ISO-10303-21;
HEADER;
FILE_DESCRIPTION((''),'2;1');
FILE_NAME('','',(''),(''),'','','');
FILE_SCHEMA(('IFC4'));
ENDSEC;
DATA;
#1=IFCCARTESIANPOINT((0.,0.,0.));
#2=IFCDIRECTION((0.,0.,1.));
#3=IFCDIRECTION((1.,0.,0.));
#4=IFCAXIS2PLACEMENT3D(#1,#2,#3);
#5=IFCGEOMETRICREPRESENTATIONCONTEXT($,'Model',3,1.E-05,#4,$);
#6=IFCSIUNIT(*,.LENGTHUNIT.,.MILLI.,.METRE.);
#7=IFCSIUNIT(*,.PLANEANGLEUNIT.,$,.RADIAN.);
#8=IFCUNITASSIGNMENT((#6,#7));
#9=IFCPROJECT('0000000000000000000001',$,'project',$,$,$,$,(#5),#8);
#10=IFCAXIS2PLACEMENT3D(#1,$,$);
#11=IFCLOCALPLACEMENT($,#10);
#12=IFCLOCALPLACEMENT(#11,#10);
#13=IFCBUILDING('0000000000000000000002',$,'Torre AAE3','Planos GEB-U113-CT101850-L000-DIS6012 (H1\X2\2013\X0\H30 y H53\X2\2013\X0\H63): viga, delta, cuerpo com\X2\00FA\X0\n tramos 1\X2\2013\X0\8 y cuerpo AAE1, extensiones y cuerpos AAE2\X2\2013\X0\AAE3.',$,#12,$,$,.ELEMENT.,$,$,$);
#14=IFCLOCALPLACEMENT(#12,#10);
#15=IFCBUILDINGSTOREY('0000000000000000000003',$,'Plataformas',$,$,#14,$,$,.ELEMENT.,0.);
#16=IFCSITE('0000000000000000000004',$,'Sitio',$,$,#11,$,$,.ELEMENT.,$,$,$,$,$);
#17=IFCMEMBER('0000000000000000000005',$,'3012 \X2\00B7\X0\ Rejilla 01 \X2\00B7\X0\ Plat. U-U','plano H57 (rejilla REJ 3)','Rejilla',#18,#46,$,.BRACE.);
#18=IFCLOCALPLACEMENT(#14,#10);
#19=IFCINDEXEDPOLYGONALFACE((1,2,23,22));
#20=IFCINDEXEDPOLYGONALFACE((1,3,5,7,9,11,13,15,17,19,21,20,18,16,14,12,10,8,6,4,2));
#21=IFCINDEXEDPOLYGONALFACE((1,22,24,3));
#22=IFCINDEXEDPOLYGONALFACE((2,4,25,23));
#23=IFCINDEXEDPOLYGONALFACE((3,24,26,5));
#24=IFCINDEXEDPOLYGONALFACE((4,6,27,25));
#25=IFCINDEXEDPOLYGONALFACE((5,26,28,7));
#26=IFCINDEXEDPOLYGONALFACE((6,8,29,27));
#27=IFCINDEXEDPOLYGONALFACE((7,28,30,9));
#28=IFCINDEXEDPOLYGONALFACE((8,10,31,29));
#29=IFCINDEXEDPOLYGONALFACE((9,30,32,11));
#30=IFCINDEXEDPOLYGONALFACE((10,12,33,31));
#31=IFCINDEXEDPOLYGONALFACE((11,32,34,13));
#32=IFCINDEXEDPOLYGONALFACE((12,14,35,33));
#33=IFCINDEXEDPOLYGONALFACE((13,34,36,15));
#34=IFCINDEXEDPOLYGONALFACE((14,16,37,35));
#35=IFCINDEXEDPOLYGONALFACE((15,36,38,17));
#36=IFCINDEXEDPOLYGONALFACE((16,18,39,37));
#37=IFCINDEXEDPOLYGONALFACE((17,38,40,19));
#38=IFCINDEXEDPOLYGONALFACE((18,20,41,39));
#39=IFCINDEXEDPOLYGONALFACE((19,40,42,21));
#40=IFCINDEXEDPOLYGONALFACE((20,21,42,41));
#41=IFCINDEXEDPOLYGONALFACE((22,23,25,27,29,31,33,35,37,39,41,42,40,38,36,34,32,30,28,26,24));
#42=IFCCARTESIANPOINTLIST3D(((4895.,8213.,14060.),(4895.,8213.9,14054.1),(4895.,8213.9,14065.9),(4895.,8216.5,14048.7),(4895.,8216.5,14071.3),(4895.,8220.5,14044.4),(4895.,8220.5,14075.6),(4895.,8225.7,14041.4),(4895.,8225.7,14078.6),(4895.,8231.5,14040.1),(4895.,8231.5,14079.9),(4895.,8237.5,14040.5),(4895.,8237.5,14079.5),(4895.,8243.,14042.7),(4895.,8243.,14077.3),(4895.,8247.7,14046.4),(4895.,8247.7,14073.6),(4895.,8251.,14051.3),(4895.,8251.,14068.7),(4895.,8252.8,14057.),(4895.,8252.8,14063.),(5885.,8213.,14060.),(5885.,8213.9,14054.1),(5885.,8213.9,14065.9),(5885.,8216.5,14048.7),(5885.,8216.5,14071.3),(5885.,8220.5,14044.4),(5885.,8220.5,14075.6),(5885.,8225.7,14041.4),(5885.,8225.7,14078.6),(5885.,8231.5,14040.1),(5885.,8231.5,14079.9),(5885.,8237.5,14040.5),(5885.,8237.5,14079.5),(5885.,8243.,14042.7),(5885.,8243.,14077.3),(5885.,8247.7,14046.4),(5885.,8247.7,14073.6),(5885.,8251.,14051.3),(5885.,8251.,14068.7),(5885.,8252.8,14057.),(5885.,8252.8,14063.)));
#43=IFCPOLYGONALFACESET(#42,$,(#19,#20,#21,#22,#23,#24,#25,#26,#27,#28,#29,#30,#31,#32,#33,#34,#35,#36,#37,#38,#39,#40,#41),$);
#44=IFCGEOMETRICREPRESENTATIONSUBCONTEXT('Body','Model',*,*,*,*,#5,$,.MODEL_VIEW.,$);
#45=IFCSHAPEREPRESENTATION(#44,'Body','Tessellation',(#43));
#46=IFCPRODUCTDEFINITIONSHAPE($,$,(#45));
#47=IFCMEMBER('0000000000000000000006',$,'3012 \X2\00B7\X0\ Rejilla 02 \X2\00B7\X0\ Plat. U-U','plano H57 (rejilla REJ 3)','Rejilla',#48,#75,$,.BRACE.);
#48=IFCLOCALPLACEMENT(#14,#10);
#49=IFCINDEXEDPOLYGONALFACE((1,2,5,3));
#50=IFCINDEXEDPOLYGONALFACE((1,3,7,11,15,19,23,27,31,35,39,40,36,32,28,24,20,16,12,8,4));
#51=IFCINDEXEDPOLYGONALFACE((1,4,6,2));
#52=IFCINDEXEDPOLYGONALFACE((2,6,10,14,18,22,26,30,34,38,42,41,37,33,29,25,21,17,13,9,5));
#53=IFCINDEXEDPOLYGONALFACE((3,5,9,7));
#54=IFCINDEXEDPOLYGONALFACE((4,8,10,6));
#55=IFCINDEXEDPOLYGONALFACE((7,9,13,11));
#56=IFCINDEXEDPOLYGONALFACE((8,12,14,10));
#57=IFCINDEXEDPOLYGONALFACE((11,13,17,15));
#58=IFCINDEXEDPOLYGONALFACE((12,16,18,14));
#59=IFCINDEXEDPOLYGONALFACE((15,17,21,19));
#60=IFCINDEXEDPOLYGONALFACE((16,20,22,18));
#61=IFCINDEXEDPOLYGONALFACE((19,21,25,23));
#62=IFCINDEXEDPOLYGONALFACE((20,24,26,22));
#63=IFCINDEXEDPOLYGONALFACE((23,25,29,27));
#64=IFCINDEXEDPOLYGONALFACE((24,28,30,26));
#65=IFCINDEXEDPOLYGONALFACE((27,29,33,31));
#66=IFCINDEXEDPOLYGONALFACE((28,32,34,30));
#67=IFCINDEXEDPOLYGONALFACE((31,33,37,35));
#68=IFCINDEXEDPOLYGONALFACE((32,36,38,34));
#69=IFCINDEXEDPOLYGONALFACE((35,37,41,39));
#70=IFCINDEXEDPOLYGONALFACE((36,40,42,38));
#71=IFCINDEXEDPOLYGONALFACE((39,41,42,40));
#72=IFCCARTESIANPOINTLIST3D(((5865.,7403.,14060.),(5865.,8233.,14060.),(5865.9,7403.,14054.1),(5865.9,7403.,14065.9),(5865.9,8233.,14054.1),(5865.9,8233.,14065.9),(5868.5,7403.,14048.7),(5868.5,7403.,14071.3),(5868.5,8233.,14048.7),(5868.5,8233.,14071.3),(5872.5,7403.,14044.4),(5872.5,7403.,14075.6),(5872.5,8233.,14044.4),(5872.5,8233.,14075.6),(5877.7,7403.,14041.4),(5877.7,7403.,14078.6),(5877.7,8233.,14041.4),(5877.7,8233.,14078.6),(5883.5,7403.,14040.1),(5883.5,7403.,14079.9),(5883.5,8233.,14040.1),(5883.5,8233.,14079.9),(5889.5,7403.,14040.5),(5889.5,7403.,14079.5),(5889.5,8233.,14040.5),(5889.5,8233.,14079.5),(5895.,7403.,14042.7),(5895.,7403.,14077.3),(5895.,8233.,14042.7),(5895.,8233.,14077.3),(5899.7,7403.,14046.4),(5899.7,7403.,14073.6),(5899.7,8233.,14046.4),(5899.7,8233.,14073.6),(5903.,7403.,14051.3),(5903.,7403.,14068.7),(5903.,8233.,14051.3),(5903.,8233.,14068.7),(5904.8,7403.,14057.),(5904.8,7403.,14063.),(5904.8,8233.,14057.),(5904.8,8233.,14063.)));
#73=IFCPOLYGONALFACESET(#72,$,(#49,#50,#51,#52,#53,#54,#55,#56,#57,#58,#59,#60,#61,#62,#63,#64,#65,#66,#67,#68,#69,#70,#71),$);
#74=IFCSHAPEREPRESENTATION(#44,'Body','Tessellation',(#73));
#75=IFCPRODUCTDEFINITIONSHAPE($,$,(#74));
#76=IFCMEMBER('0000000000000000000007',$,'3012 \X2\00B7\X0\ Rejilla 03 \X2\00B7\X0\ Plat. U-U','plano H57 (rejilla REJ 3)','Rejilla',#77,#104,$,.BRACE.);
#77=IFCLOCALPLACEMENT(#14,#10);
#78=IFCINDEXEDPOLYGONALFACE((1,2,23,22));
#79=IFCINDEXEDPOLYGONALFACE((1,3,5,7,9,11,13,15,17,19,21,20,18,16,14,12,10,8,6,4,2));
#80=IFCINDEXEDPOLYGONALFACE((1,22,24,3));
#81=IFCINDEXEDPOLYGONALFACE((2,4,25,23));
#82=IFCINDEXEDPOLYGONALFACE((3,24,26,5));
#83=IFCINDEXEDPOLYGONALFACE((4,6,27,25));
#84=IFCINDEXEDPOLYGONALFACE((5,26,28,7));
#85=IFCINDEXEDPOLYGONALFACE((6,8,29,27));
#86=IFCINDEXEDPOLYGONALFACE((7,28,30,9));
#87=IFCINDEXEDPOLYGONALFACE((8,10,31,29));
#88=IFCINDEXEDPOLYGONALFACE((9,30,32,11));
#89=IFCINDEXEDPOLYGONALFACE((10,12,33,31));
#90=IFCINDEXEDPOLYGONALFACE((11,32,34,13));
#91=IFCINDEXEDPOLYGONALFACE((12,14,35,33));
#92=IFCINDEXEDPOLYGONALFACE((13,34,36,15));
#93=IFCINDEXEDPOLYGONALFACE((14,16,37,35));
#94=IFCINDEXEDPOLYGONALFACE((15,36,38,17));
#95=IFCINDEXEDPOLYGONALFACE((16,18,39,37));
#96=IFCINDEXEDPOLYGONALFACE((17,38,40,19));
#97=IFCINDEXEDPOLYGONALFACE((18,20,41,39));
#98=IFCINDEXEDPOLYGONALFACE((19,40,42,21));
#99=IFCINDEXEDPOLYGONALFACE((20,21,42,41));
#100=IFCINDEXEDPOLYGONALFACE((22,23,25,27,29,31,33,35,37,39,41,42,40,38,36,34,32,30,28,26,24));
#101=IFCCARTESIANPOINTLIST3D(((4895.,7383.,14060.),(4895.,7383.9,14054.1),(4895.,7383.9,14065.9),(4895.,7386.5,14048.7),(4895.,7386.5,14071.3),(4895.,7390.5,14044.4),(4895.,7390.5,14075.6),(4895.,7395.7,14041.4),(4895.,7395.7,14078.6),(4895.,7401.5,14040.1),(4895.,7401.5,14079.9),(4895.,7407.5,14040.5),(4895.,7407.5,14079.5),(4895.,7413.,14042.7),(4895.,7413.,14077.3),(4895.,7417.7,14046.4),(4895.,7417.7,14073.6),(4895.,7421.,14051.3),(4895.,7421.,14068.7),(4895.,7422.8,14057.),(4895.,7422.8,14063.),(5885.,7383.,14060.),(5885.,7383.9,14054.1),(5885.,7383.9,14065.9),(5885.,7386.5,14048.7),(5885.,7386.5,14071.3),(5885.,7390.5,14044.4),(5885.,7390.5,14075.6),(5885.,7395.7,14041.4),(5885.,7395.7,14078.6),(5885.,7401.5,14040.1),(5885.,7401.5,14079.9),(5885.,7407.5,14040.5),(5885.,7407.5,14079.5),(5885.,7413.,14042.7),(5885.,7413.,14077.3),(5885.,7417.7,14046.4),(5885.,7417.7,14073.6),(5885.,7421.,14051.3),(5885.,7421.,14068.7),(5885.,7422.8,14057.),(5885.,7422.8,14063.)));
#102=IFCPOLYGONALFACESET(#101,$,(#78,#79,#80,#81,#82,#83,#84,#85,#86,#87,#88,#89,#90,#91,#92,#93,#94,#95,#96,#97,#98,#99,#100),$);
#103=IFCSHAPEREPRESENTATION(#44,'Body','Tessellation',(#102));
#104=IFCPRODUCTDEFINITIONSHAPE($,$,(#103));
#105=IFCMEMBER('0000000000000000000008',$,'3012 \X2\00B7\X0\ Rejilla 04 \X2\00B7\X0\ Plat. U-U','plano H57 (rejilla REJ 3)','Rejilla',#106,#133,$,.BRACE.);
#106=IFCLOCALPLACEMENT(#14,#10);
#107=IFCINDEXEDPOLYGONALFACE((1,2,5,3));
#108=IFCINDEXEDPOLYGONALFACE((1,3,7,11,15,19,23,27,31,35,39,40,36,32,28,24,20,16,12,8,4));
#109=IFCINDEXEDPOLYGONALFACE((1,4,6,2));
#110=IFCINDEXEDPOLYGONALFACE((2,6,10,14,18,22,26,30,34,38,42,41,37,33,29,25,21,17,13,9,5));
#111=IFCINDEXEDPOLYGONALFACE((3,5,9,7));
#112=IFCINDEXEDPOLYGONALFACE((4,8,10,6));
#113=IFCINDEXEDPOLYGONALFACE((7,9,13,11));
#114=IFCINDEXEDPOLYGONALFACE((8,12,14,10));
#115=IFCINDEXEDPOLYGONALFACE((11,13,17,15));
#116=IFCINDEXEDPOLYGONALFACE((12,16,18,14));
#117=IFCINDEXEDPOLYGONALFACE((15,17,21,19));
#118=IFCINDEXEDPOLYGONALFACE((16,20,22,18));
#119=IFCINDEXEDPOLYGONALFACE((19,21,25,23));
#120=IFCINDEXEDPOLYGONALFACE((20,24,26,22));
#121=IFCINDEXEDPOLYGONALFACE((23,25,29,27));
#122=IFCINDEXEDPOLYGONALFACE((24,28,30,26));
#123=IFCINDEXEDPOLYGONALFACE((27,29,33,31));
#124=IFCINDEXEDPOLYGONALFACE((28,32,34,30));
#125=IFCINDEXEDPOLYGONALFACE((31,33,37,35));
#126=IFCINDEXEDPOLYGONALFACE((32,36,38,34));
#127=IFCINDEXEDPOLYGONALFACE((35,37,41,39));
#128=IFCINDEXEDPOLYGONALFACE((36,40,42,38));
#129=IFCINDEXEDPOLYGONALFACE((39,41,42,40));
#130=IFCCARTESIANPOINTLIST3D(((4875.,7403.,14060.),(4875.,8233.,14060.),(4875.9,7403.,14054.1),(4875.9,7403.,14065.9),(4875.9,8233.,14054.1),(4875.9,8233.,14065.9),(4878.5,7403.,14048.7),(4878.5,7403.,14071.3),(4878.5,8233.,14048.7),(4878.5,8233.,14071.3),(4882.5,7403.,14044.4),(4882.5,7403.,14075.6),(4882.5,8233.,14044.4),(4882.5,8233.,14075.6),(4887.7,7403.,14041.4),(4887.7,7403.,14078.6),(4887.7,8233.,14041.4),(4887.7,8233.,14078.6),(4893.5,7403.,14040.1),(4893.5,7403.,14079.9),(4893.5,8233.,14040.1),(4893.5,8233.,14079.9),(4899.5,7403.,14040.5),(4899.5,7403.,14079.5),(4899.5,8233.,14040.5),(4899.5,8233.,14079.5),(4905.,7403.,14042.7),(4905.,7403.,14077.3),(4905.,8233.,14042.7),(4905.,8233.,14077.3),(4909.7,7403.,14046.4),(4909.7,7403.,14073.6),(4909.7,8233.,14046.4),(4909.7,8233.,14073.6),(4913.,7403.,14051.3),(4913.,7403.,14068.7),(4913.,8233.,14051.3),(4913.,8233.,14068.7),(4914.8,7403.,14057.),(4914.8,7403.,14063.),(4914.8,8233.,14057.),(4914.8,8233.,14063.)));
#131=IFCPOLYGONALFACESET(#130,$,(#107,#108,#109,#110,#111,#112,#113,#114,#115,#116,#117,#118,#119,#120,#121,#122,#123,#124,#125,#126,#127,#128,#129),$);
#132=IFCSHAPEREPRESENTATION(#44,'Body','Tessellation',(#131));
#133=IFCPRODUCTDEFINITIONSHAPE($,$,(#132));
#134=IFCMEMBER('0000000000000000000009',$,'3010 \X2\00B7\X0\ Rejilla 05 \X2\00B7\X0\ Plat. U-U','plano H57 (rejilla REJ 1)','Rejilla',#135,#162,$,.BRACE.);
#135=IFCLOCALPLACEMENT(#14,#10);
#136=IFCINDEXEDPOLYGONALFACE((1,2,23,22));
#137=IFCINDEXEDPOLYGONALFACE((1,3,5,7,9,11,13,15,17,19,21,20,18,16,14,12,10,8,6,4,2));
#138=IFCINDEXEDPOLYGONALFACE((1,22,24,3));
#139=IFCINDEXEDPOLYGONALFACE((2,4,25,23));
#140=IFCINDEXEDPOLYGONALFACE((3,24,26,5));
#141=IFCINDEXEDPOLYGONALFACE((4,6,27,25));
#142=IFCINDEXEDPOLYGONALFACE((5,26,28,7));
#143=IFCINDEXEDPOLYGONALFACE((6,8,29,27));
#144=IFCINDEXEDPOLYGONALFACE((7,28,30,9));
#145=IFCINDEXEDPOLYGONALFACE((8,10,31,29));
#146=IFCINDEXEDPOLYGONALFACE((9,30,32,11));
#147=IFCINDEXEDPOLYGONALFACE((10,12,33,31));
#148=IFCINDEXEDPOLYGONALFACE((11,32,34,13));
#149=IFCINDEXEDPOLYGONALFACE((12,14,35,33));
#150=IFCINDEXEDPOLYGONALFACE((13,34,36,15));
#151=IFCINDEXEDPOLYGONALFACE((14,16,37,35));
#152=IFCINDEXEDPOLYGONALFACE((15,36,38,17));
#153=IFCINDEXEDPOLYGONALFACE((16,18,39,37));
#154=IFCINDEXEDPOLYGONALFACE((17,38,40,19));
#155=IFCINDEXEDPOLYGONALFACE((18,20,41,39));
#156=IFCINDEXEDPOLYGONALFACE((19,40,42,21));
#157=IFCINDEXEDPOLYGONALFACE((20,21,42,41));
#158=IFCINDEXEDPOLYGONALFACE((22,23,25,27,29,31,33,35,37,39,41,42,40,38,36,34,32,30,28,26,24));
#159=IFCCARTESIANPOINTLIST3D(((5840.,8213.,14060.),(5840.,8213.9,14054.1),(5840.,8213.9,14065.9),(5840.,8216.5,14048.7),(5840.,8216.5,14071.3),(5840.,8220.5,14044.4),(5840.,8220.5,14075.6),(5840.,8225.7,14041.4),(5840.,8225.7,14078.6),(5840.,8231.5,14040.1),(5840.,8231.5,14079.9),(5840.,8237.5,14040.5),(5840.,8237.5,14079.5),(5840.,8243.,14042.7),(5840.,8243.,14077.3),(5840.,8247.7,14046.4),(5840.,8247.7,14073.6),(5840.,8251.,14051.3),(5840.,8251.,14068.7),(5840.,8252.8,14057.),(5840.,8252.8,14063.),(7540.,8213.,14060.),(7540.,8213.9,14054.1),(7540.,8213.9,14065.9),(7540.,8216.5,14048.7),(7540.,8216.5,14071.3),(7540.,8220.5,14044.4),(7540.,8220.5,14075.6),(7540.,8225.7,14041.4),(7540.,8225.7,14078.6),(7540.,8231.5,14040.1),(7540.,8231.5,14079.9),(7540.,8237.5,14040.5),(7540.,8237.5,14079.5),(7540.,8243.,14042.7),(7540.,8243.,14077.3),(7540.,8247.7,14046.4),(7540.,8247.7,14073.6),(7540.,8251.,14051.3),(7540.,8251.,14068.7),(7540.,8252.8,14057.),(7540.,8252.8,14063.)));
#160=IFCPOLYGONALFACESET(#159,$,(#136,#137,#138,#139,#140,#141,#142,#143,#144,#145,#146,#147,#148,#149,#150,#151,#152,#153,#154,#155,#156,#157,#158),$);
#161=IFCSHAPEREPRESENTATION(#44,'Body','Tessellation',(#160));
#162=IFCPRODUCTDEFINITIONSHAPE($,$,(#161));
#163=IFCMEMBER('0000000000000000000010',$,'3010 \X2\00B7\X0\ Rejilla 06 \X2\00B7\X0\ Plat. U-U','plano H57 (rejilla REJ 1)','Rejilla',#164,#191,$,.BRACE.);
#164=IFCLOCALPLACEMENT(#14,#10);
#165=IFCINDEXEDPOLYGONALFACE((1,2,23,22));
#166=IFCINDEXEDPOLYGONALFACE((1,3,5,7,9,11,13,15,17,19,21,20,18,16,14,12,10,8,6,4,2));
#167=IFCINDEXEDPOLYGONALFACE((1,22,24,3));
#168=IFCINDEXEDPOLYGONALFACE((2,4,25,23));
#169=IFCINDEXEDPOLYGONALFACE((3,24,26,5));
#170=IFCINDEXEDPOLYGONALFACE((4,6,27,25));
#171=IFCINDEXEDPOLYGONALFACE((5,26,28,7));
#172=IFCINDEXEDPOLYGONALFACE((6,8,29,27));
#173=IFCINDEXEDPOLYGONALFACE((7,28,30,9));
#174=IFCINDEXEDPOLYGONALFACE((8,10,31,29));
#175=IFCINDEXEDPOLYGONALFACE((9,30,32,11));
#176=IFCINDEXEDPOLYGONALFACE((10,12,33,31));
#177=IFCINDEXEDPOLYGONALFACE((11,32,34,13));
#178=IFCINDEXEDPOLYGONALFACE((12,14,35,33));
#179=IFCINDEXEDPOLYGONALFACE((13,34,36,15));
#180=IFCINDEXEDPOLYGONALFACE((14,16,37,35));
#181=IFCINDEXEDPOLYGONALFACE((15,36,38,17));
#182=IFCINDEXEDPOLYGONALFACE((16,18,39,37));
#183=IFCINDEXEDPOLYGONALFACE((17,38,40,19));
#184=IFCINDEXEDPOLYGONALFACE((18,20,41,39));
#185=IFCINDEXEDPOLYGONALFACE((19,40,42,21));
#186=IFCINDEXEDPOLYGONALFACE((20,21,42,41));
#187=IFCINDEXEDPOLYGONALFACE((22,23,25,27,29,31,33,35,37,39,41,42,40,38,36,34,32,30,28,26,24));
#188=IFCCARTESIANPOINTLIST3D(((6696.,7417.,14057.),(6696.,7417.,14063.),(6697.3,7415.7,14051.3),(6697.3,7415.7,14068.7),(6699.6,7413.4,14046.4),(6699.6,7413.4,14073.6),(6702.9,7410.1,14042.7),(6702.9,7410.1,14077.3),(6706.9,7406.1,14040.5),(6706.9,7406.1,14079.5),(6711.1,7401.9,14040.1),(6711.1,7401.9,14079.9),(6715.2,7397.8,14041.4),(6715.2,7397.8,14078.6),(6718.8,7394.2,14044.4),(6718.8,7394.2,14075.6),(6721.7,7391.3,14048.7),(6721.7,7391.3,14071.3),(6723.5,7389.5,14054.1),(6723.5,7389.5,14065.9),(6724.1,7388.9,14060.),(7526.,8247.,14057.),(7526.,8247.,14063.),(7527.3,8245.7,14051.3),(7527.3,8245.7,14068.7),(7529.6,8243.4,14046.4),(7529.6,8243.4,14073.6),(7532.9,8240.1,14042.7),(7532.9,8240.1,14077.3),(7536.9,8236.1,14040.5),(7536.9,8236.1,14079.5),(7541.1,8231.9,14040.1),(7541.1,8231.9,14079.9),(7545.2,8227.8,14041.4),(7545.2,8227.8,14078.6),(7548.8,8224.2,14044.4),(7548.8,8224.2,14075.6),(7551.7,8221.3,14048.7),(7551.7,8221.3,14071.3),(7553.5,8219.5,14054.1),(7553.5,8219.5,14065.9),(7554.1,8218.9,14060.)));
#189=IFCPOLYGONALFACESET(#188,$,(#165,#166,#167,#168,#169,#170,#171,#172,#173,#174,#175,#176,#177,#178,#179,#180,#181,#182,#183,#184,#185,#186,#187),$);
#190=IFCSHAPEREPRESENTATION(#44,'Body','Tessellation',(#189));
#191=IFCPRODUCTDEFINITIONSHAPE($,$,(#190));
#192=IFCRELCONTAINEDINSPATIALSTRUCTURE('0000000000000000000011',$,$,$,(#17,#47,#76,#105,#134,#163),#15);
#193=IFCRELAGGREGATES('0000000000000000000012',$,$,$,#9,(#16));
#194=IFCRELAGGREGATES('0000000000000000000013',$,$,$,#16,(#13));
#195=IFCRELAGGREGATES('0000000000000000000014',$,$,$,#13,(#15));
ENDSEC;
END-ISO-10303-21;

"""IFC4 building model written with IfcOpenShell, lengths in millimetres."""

from ifc_helpers import new_model, si_unit, frame, origin, origin_with_axes, place, context, subcontext, project, spatial, circle, extrude, element, save


model = new_model("IFC4")

# Units and contexts
model_context = context("Model", 3, precision=1e-05, world=origin_with_axes())
body_context = subcontext(model_context, "Body", "Model", "MODEL_VIEW")
ifc_project = project(units=[si_unit("LENGTHUNIT", "METRE", prefix="MILLI"), si_unit("PLANEANGLEUNIT", "RADIAN")], contexts=[model_context])

# Site, building, storey
site_placement = place(None, origin())
site = spatial("IfcSite", under=ifc_project, at=site_placement, Name="Sitio", CompositionType="ELEMENT")
building_placement = place(site_placement, origin())
building = spatial("IfcBuilding", under=site, at=building_placement, Name="Torre AAE3", Description="Planos GEB-U113-CT101850-L000-DIS6012 (H1–H30 y H53–H63): viga, delta, cuerpo común tramos 1–8 y cuerpo AAE1, extensiones y cuerpos AAE2–AAE3.", CompositionType="ELEMENT")
storey_placement = place(building_placement, origin())
storey = spatial("IfcBuildingStorey", under=building, at=storey_placement, Name="Plataformas", CompositionType="ELEMENT", Elevation=0.0)

# Members
member_1_placement = place(storey_placement, frame((4895.0, 8233.0, 14060.0), z_axis=(1.0, 0.0, 0.0), x_axis=(0.0, -1.0, 0.0)))
element("IfcMember", 1, at=member_1_placement, inside=storey, Name="3012 · Rejilla 01 · Plat. U-U", Description="plano H57 (rejilla REJ 3)", ObjectType="Rejilla", PredefinedType="BRACE", context=body_context, shape_type="SweptSolid", body=[
    extrude(circle(Radius=20.0), None, (0.0, 0.0, 1.0), 990.0),
])
member_2_placement = place(storey_placement, frame((5885.0, 8233.0, 14060.0), z_axis=(0.0, -1.0, 0.0), x_axis=(-1.0, 0.0, 0.0)))
element("IfcMember", 2, at=member_2_placement, inside=storey, Name="3012 · Rejilla 02 · Plat. U-U", Description="plano H57 (rejilla REJ 3)", ObjectType="Rejilla", PredefinedType="BRACE", context=body_context, shape_type="SweptSolid", body=[
    extrude(circle(Radius=20.0), None, (0.0, 0.0, 1.0), 830.0),
])
member_3_placement = place(storey_placement, frame((5885.0, 7403.0, 14060.0), z_axis=(-1.0, 0.0, 0.0), x_axis=(0.0, -1.0, 0.0)))
element("IfcMember", 3, at=member_3_placement, inside=storey, Name="3012 · Rejilla 03 · Plat. U-U", Description="plano H57 (rejilla REJ 3)", ObjectType="Rejilla", PredefinedType="BRACE", context=body_context, shape_type="SweptSolid", body=[
    extrude(circle(Radius=20.0), None, (0.0, 0.0, 1.0), 990.0),
])
member_4_placement = place(storey_placement, frame((4895.0, 7403.0, 14060.0), z_axis=(0.0, 1.0, 0.0), x_axis=(-1.0, 0.0, 0.0)))
element("IfcMember", 4, at=member_4_placement, inside=storey, Name="3012 · Rejilla 04 · Plat. U-U", Description="plano H57 (rejilla REJ 3)", ObjectType="Rejilla", PredefinedType="BRACE", context=body_context, shape_type="SweptSolid", body=[
    extrude(circle(Radius=20.0), None, (0.0, 0.0, 1.0), 830.0),
])
member_5_placement = place(storey_placement, frame((5840.0, 8233.0, 14060.0), z_axis=(1.0, 0.0, 0.0), x_axis=(0.0, -1.0, 0.0)))
element("IfcMember", 5, at=member_5_placement, inside=storey, Name="3010 · Rejilla 05 · Plat. U-U", Description="plano H57 (rejilla REJ 1)", ObjectType="Rejilla", PredefinedType="BRACE", context=body_context, shape_type="SweptSolid", body=[
    extrude(circle(Radius=20.0), None, (0.0, 0.0, 1.0), 1700.0),
])
member_6_placement = place(storey_placement, frame((7540.0, 8233.0, 14060.0), z_axis=(-0.707107, -0.707107, 0.0), x_axis=(0.707107, -0.707107, 0.0)))
element("IfcMember", 6, at=member_6_placement, inside=storey, Name="3010 · Rejilla 06 · Plat. U-U", Description="plano H57 (rejilla REJ 1)", ObjectType="Rejilla", PredefinedType="BRACE", context=body_context, shape_type="SweptSolid", body=[
    extrude(circle(Radius=20.0), None, (0.0, 0.0, 1.0), 1173.8),
])

save(model, "model.ifc")
